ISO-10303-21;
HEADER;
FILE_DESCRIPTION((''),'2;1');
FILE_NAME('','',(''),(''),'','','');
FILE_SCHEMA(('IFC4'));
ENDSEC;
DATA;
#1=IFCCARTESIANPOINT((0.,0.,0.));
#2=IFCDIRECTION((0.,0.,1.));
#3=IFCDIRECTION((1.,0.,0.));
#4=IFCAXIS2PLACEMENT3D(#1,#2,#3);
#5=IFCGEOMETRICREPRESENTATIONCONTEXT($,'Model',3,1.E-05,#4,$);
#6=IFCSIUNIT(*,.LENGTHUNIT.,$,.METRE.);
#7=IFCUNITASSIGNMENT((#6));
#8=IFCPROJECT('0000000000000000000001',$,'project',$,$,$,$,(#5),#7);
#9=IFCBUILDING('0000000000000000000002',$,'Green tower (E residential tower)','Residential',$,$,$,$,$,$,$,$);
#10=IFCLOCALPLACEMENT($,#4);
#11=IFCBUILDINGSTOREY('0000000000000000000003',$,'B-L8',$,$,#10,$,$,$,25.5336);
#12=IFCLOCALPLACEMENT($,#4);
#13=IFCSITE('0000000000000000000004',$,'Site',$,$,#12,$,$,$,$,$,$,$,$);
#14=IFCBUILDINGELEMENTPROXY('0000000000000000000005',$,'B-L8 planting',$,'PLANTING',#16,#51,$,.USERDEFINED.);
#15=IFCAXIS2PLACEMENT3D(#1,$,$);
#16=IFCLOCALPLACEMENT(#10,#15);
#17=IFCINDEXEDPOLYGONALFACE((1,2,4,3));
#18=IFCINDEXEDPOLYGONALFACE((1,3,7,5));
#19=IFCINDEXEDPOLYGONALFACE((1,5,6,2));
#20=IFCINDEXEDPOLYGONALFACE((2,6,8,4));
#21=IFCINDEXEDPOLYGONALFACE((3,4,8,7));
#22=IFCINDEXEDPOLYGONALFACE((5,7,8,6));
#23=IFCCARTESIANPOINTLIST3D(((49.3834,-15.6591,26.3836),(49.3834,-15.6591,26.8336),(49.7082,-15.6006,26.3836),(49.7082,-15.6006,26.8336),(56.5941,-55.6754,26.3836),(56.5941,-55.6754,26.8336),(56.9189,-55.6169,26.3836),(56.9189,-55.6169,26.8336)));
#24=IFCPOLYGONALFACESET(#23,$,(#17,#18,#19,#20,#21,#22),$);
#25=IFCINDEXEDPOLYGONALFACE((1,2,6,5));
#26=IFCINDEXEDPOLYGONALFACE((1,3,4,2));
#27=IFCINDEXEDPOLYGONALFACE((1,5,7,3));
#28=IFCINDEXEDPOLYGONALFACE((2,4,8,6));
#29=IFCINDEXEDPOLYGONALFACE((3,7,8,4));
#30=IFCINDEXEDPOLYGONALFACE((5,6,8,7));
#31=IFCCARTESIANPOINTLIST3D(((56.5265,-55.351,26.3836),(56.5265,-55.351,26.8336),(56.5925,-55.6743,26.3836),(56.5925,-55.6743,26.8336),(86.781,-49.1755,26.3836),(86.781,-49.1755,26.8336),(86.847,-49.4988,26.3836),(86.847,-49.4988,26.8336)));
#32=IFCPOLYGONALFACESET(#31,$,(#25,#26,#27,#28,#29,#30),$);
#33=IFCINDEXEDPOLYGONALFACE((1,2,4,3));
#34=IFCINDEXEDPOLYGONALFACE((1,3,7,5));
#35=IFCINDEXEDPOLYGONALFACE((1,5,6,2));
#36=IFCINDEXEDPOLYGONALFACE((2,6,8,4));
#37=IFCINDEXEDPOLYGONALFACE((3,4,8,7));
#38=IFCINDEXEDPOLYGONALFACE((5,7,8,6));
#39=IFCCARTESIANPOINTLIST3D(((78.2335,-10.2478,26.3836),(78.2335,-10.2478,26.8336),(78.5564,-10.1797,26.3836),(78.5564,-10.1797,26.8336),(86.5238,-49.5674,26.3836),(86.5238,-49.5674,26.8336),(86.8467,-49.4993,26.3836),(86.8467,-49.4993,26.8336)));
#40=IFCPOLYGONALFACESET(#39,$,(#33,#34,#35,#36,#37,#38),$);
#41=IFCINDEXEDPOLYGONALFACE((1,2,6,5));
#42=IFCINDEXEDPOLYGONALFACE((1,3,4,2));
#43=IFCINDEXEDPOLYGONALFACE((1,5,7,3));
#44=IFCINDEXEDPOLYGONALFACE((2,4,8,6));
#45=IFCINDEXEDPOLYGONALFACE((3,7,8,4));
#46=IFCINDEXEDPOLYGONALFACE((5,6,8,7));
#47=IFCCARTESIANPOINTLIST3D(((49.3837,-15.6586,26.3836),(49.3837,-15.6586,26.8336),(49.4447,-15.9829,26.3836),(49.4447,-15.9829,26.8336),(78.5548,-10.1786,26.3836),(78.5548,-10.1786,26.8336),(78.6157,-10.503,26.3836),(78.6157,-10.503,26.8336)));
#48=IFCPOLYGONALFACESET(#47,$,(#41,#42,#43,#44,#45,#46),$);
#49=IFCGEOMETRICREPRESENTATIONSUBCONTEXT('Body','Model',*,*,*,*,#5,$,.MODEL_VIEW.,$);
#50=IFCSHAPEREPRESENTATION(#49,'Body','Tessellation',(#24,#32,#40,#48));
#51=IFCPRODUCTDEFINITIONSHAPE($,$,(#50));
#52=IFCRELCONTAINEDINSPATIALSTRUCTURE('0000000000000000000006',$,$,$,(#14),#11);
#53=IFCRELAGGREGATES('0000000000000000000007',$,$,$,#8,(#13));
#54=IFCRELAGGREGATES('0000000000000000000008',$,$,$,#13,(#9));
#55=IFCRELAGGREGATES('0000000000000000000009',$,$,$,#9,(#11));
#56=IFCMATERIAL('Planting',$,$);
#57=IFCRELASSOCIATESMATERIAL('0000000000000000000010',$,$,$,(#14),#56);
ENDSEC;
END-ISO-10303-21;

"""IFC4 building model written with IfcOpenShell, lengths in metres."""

from ifc_helpers import new_model, si_unit, frame, origin_with_axes, place, context, subcontext, project, spatial, polyline, outline, extrude, material, element, save


model = new_model("IFC4")

# Units and contexts
model_context = context("Model", 3, precision=1e-05, world=origin_with_axes())
body_context = subcontext(model_context, "Body", "Model", "MODEL_VIEW")
ifc_project = project(units=[si_unit("LENGTHUNIT", "METRE")], contexts=[model_context])

# Site, building, storey
site_placement = place(None, origin_with_axes())
site = spatial("IfcSite", under=ifc_project, at=site_placement, Name="Site")
building = spatial("IfcBuilding", under=site, Name="Green tower (E residential tower)", Description="Residential")
storey_placement = place(None, origin_with_axes())
storey = spatial("IfcBuildingStorey", under=building, at=storey_placement, Name="B-L8", Elevation=25.5336)

# Building element proxy
ifc_material_1 = material(Name="Planting")
proxy_1_placement = place(storey_placement, origin_with_axes())
element("IfcBuildingElementProxy", 1, at=proxy_1_placement, inside=storey, material=ifc_material_1, Name="B-L8 planting", ObjectType="PLANTING", PredefinedType="USERDEFINED", context=body_context, shape_type="SweptSolid", body=[
    extrude(outline(polyline([(49.3834, -15.6591), (56.5941, -55.6754), (56.9189, -55.6169), (49.7082, -15.6006), (49.3834, -15.6591)])), frame((0.0, 0.0, 26.3836), z_axis=(0.0, 0.0, 1.0), x_axis=(1.0, 0.0, 0.0)), (0.0, 0.0, 1.0), 0.45),
    extrude(outline(polyline([(56.5925, -55.6743), (86.847, -49.4988), (86.781, -49.1755), (56.5265, -55.351), (56.5925, -55.6743)])), frame((0.0, 0.0, 26.3836), z_axis=(0.0, 0.0, 1.0), x_axis=(1.0, 0.0, 0.0)), (0.0, 0.0, 1.0), 0.45),
    extrude(outline(polyline([(86.8467, -49.4993), (78.5564, -10.1797), (78.2335, -10.2478), (86.5238, -49.5674), (86.8467, -49.4993)])), frame((0.0, 0.0, 26.3836), z_axis=(0.0, 0.0, 1.0), x_axis=(1.0, 0.0, 0.0)), (0.0, 0.0, 1.0), 0.45),
    extrude(outline(polyline([(78.5548, -10.1786), (49.3837, -15.6586), (49.4447, -15.9829), (78.6157, -10.503), (78.5548, -10.1786)])), frame((0.0, 0.0, 26.3836), z_axis=(0.0, 0.0, 1.0), x_axis=(1.0, 0.0, 0.0)), (0.0, 0.0, 1.0), 0.45),
])

save(model, "model.ifc")
